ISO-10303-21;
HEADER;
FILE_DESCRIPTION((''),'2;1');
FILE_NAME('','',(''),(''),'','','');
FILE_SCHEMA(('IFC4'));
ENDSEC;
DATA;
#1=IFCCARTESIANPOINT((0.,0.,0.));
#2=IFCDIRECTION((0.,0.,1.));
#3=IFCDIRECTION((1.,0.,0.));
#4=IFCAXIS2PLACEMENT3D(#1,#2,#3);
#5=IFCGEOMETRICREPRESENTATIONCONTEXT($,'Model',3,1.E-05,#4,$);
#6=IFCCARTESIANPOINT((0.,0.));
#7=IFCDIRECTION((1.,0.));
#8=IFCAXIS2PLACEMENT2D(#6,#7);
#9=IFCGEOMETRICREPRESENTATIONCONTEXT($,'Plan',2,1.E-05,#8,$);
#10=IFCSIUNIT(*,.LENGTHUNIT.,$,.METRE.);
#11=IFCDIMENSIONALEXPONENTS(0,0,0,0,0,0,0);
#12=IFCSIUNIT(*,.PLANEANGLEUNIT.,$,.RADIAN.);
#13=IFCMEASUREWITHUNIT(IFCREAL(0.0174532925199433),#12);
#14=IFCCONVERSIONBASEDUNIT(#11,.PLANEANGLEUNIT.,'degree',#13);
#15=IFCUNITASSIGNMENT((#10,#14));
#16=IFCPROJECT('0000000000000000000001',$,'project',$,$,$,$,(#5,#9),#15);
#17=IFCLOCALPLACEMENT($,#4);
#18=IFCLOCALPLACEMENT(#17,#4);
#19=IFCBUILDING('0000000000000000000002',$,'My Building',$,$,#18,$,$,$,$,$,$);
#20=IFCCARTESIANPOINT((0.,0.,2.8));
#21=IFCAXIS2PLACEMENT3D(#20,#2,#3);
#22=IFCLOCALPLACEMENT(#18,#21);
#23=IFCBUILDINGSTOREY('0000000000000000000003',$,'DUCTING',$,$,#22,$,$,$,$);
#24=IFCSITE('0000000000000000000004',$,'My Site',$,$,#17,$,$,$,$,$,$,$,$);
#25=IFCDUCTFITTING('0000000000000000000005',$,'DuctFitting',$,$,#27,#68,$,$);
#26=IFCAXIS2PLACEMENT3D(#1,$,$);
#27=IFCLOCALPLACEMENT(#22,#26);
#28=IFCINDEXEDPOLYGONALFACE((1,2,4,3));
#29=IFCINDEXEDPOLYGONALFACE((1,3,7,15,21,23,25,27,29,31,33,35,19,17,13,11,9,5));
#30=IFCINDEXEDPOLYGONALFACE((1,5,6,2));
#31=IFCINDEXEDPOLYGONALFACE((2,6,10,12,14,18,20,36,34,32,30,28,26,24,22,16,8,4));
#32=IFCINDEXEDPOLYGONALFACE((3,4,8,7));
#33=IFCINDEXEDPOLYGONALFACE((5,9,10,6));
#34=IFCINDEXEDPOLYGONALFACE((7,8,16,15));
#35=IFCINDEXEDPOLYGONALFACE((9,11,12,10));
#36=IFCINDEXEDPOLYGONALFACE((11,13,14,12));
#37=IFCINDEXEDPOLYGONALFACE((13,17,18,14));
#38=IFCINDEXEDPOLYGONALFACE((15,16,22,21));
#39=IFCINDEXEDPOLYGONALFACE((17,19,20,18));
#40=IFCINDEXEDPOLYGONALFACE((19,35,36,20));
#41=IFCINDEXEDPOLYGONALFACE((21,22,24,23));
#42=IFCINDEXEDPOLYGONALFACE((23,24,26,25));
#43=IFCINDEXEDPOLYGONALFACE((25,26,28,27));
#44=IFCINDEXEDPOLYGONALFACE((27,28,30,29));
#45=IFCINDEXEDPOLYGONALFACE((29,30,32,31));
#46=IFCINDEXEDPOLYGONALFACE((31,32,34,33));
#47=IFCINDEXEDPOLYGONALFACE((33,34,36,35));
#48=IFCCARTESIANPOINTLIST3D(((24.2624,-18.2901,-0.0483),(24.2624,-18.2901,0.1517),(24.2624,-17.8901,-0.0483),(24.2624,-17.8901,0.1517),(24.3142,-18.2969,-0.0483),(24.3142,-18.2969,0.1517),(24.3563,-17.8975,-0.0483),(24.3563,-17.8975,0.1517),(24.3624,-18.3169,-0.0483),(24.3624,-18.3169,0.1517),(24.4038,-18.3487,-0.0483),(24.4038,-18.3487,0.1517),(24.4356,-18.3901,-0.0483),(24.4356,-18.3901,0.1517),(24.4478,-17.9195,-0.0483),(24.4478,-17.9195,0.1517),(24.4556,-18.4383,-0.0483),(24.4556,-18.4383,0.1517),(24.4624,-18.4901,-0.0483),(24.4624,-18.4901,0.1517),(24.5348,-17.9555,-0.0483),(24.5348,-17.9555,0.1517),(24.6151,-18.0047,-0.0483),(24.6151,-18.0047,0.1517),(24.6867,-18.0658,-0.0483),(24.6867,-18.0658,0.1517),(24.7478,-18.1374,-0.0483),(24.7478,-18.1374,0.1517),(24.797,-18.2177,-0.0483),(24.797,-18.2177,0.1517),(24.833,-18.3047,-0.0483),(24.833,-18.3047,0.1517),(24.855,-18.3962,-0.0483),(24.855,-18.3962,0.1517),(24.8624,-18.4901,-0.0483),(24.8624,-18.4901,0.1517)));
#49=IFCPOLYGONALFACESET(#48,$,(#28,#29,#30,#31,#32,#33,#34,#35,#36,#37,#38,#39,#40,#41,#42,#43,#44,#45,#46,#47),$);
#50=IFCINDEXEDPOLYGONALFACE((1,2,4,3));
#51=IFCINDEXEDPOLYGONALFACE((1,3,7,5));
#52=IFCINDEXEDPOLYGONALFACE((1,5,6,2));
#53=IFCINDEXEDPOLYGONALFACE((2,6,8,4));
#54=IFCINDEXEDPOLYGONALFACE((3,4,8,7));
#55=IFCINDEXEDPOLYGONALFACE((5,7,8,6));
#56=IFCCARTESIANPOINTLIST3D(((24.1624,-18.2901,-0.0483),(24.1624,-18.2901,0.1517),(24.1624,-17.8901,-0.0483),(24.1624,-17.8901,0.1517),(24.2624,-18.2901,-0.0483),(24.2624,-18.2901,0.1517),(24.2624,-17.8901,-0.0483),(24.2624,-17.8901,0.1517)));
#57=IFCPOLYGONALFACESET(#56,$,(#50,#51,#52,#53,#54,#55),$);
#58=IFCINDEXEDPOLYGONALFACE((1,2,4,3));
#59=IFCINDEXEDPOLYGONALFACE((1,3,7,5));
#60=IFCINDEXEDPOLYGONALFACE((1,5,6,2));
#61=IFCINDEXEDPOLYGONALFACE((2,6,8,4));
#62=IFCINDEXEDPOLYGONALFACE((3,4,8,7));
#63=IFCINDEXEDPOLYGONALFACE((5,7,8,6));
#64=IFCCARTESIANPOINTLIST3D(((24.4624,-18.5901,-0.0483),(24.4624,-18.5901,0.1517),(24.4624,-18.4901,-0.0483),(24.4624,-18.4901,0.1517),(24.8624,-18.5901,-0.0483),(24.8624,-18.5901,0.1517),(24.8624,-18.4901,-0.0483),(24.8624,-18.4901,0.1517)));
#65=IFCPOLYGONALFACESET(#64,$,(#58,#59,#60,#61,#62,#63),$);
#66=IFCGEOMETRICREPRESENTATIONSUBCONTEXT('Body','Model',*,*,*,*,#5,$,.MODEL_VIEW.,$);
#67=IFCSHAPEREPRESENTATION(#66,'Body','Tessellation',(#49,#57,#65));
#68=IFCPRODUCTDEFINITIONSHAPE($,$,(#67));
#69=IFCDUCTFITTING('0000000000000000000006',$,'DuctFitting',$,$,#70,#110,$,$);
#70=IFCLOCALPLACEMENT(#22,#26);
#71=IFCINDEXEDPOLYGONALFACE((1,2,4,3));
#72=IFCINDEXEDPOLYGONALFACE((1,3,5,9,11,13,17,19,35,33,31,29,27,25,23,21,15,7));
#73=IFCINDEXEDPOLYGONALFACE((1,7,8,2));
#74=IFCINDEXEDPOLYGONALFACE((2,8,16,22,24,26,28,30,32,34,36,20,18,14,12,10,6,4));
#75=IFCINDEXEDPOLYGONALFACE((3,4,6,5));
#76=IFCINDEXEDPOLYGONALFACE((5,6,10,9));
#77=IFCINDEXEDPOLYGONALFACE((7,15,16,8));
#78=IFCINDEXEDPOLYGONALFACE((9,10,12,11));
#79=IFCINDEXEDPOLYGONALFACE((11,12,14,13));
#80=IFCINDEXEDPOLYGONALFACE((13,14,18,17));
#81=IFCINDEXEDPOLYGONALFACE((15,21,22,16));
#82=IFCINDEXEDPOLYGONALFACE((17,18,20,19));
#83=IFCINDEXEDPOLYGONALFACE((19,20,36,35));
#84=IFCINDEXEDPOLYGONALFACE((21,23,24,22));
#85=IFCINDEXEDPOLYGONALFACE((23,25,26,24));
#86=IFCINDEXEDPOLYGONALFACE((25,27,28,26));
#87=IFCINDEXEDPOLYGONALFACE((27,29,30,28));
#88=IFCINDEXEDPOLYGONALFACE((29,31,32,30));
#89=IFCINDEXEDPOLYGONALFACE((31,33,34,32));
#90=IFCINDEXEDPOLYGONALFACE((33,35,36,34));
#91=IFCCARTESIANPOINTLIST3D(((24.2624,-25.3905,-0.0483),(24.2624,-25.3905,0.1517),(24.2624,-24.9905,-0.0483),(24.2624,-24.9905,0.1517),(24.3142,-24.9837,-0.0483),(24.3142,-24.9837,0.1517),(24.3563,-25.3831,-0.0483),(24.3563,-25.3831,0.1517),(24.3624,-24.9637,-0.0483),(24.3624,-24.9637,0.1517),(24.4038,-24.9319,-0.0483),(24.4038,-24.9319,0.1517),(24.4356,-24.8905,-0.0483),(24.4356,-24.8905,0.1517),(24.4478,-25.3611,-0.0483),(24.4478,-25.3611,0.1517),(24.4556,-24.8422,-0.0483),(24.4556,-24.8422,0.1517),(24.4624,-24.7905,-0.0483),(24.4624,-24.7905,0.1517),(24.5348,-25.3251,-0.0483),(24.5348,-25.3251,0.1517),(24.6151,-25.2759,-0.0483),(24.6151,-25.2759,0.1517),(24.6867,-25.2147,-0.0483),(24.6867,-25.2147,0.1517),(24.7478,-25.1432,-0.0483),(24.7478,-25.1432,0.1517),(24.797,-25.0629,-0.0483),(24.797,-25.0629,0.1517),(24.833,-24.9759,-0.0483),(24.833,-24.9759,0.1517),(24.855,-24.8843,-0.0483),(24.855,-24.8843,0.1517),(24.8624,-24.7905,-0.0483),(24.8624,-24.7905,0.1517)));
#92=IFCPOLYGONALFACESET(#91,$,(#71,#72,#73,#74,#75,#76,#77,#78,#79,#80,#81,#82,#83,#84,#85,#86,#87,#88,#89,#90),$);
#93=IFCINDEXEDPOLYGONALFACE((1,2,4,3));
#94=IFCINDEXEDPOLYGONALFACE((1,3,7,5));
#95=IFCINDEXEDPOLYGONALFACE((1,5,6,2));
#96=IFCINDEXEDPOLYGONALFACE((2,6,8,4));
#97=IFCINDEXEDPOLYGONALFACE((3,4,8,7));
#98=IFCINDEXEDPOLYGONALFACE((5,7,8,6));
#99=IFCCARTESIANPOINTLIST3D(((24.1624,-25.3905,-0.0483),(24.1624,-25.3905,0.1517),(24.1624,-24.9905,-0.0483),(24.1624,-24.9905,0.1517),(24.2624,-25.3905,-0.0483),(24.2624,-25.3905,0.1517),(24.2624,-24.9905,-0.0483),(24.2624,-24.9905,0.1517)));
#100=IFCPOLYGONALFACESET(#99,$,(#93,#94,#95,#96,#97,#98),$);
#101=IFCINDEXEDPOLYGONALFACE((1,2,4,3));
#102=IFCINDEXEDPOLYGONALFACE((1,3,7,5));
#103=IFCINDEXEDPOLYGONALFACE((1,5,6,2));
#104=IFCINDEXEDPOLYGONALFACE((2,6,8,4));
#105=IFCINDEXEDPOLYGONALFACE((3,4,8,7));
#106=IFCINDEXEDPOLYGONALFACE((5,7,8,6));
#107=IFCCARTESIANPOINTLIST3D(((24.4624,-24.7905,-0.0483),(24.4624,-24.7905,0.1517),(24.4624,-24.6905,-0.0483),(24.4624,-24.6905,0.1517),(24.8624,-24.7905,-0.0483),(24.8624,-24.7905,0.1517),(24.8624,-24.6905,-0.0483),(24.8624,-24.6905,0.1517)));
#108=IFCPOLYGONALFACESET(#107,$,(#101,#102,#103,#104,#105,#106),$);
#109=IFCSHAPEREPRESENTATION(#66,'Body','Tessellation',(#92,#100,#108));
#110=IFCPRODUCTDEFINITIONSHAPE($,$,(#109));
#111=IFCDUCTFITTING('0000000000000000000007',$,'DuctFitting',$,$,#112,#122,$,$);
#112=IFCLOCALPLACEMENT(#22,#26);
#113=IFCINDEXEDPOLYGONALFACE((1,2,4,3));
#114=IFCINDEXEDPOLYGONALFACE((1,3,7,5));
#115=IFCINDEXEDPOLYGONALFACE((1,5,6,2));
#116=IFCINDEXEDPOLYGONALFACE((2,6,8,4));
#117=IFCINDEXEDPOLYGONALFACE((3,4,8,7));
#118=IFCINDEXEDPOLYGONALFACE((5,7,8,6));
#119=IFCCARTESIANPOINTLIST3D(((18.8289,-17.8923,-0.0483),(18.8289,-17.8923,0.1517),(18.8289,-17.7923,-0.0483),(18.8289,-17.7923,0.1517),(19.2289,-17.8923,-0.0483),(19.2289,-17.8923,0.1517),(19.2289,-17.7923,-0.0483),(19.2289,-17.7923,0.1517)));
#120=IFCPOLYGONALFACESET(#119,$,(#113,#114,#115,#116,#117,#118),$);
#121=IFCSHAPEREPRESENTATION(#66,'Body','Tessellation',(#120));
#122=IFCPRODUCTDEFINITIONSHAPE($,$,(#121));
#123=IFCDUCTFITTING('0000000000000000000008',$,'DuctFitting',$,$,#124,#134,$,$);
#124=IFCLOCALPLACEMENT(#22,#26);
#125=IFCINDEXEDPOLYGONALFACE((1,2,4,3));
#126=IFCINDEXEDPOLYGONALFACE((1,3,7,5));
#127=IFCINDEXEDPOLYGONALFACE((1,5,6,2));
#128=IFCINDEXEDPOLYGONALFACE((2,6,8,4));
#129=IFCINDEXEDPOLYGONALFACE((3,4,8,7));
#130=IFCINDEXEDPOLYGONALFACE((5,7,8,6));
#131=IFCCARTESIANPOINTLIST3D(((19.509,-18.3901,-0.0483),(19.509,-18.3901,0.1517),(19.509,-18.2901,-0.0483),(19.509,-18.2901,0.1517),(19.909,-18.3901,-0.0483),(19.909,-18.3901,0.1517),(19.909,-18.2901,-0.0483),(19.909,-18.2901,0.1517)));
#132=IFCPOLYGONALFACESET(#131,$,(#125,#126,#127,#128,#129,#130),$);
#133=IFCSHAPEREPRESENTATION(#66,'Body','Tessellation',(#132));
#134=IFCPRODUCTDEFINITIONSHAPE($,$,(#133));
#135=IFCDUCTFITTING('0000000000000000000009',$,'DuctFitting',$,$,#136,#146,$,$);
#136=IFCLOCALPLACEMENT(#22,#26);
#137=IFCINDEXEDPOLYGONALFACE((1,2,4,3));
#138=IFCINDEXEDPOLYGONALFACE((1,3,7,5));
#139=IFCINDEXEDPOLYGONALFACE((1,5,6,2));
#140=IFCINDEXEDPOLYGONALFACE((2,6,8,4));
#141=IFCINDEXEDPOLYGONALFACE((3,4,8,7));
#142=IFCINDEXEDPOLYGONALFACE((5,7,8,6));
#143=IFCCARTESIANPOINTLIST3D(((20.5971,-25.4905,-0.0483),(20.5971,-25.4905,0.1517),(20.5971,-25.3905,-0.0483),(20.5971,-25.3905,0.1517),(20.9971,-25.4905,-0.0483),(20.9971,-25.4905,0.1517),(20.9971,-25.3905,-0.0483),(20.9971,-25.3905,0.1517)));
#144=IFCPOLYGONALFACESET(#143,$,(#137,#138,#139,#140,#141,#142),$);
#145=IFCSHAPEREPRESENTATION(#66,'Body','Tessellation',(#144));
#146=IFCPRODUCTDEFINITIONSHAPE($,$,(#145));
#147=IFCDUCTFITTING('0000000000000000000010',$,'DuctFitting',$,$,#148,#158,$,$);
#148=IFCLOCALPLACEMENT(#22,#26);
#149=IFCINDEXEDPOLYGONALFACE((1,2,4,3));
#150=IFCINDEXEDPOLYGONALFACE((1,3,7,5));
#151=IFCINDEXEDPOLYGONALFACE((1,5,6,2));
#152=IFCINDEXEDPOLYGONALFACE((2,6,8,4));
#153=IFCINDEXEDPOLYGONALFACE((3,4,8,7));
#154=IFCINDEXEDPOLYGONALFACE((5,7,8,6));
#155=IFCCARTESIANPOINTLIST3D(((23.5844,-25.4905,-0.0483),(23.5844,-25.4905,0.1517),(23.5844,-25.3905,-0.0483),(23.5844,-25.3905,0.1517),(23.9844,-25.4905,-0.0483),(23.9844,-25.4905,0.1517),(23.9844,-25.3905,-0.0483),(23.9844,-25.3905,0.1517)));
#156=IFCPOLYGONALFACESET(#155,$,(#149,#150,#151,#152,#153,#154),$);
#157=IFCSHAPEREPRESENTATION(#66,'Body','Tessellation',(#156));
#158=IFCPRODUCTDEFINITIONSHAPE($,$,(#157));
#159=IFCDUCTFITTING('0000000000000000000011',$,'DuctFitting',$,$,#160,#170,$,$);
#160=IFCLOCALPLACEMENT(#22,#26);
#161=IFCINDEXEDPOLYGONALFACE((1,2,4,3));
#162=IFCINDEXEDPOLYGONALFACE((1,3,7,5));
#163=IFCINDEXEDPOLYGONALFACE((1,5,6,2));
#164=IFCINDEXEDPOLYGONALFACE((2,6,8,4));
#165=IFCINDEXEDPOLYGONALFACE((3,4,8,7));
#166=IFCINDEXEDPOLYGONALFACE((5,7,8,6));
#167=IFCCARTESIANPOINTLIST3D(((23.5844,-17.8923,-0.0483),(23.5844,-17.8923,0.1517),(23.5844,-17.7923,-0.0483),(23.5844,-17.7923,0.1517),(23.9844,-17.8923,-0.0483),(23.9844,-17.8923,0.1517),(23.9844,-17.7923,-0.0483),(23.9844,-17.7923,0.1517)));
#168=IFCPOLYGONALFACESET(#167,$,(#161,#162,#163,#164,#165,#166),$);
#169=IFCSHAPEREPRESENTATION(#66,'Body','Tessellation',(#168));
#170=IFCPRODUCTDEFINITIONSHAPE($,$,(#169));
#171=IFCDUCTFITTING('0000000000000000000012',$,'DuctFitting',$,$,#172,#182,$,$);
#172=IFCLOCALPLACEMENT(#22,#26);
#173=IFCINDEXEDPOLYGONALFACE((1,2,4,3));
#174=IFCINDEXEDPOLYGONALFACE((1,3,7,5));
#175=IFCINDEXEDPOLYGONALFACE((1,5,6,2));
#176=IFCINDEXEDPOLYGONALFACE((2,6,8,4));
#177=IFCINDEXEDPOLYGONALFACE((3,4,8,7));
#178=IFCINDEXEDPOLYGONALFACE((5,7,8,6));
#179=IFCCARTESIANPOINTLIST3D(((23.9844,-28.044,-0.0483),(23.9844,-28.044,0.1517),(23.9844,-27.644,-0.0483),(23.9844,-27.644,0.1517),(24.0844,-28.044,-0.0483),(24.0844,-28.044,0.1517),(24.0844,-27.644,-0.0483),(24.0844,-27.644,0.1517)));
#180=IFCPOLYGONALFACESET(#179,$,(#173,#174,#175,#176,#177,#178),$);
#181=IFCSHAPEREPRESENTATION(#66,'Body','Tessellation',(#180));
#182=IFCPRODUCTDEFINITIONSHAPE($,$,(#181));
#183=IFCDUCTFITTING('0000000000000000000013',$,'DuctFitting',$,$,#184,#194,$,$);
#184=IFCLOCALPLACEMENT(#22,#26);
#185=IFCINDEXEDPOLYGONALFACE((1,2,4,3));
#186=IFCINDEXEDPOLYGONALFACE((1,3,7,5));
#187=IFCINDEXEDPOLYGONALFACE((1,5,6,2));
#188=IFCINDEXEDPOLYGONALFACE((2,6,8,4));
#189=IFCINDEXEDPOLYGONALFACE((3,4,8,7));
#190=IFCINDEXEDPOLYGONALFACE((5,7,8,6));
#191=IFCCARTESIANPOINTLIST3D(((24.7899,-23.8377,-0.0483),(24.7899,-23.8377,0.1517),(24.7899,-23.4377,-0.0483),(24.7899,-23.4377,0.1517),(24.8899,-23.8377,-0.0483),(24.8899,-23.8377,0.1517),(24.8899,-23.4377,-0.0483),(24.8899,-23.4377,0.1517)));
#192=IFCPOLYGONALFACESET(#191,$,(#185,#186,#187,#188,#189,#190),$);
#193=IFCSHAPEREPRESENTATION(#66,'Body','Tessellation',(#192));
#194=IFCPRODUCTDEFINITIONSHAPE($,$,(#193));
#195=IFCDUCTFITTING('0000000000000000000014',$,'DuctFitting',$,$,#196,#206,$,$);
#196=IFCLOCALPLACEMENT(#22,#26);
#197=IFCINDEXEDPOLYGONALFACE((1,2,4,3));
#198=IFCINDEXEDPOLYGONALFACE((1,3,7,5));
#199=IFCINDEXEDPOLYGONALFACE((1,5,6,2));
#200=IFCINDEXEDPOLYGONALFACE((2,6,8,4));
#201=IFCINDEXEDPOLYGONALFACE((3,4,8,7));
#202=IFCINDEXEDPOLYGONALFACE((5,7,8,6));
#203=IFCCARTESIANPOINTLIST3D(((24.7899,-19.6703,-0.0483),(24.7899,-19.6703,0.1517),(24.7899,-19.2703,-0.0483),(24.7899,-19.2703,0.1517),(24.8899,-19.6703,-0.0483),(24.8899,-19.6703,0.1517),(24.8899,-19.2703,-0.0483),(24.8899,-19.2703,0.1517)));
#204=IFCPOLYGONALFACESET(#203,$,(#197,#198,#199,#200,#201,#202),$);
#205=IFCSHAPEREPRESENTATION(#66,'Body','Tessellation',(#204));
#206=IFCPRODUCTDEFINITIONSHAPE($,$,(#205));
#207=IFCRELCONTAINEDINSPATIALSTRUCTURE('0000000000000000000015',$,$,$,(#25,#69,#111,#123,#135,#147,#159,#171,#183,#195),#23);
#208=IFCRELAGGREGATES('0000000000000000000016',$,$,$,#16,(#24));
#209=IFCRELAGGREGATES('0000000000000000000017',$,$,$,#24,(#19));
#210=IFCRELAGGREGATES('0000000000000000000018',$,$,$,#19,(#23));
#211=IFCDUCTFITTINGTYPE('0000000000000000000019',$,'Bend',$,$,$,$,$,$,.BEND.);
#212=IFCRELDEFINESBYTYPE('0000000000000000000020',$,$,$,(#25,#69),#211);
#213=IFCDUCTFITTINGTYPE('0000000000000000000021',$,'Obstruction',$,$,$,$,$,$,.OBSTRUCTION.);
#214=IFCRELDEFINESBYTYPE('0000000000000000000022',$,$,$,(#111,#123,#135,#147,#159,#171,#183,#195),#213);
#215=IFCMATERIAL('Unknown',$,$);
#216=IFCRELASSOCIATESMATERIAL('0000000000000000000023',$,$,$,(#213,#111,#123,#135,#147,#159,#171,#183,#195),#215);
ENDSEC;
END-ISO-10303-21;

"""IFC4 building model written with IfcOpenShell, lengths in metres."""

from ifc_helpers import new_model, entity, si_unit, converted_unit, frame, origin_with_axes, origin_2d_with_axis, place, context, subcontext, project, spatial, line, arc, indexed_curve, rectangle, outline, extrude, source, transform, mapped, material, material_profile, profile_set, profile_usage, type_object, type_shapes, element, save


model = new_model("IFC4")

# Units and contexts
model_context = context("Model", 3, precision=1e-05, world=origin_with_axes())
plan_context = context("Plan", 2, precision=1e-05, world=origin_2d_with_axis())
body_context = subcontext(model_context, "Body", "Model", "MODEL_VIEW")
ifc_project = project(units=[si_unit("LENGTHUNIT", "METRE"), converted_unit("PLANEANGLEUNIT", "degree", entity("IfcReal", 0.0174532925199433), si_unit("PLANEANGLEUNIT", "RADIAN"), dimensions=[0, 0, 0, 0, 0, 0, 0])], contexts=[model_context, plan_context])

# Site, building, storey
site_placement = place(None, origin_with_axes())
site = spatial("IfcSite", under=ifc_project, at=site_placement, Name="My Site")
building_placement = place(site_placement, origin_with_axes())
building = spatial("IfcBuilding", under=site, at=building_placement, Name="My Building")
storey_placement = place(building_placement, frame((0.0, 0.0, 2.8), z_axis=(0.0, 0.0, 1.0), x_axis=(1.0, 0.0, 0.0)))
storey = spatial("IfcBuildingStorey", under=building, at=storey_placement, Name="DUCTING")

# Shared definitions
ifc_material = material(Name="Unknown")

# Duct fittings
duct_fitting_type_1 = type_object("IfcDuctFittingType", Name="Bend", PredefinedType="BEND")
shared_shape = source(origin_with_axes(), body_context, "Body", "SweptSolid", [
    extrude(outline(indexed_curve([(0.2, 0.0), (0.2586, -0.1414), (0.4, -0.2), (0.4, -0.6), (-0.0243, -0.4243), (-0.2, 0.0)], segments=[arc(1, 2, 3), line(3, 4), arc(4, 5, 6), line(6, 1)])), frame((0.0, -0.1, -0.1), z_axis=(0.0, -1.0, 0.0), x_axis=(1.0, 0.0, 0.0)), (0.0, 0.0, -1.0), 0.2),
    extrude(rectangle(XDim=0.4, YDim=0.2), origin_with_axes(), (0.0, 0.0, -1.0), 0.1),
    extrude(rectangle(XDim=0.4, YDim=0.2), frame((0.4, 0.0, -0.5), z_axis=(1.0, 0.0, 0.0), x_axis=(0.0, 0.0, 1.0)), (0.0, 0.0, 1.0), 0.1),
])
type_shapes(duct_fitting_type_1, [shared_shape])
for number, where, z_axis, x_axis, name in (
    (1, (24.1624, -18.0901, 0.0517), (-1.0, 0.0, 0.0), (0.0, -1.0, 0.0), "DuctFitting"),
    (2, (24.1624, -25.1905, 0.0517), (-1.0, 0.0, 0.0), (0.0, 1.0, 0.0), "DuctFitting"),
):
    element("IfcDuctFitting", number, at=place(storey_placement, frame(where, z_axis=z_axis, x_axis=x_axis)), inside=storey, type_object=duct_fitting_type_1, Name=name, context=body_context, shape_type="MappedRepresentation", body=[
        mapped(shared_shape, transform((0.0, 0.0, 0.0), x_axis=(1.0, 0.0, 0.0), y_axis=(0.0, 1.0, 0.0), z_axis=(0.0, 0.0, 1.0), scale=1.0)),
    ])
ifc_material_profile_1 = material_profile(ifc_material, rectangle(XDim=0.4, YDim=0.2))
ifc_profile_set_1 = profile_set([ifc_material_profile_1])
ifc_profile_usage_1 = profile_usage(ifc_profile_set_1, cardinal=5)
duct_fitting_type_2 = type_object("IfcDuctFittingType", Name="Obstruction", PredefinedType="OBSTRUCTION", material=ifc_profile_set_1)
duct_fitting_1_placement = place(storey_placement, frame((19.0289, -17.7923, 0.0517), z_axis=(0.0, -1.0, 0.0), x_axis=(1.0, 0.0, 0.0)))
element("IfcDuctFitting", 3, at=duct_fitting_1_placement, inside=storey, type_object=duct_fitting_type_2, material=ifc_profile_usage_1, Name="DuctFitting", context=body_context, shape_type="SweptSolid", body=[
    extrude(rectangle(XDim=0.4, YDim=0.2), origin_with_axes(), (0.0, 0.0, 1.0), 0.1),
])
ifc_profile_usage_2 = profile_usage(ifc_profile_set_1, cardinal=5)
duct_fitting_2_placement = place(storey_placement, frame((19.709, -18.3901, 0.0517), z_axis=(0.0, 1.0, 0.0), x_axis=(-1.0, 0.0, 0.0)))
element("IfcDuctFitting", 4, at=duct_fitting_2_placement, inside=storey, type_object=duct_fitting_type_2, material=ifc_profile_usage_2, Name="DuctFitting", context=body_context, shape_type="SweptSolid", body=[
    extrude(rectangle(XDim=0.4, YDim=0.2), origin_with_axes(), (0.0, 0.0, 1.0), 0.1),
])
ifc_profile_usage_3 = profile_usage(ifc_profile_set_1, cardinal=5)
duct_fitting_3_placement = place(storey_placement, frame((20.7971, -25.4905, 0.0517), z_axis=(0.0, 1.0, 0.0), x_axis=(-1.0, 0.0, 0.0)))
element("IfcDuctFitting", 5, at=duct_fitting_3_placement, inside=storey, type_object=duct_fitting_type_2, material=ifc_profile_usage_3, Name="DuctFitting", context=body_context, shape_type="SweptSolid", body=[
    extrude(rectangle(XDim=0.4, YDim=0.2), origin_with_axes(), (0.0, 0.0, 1.0), 0.1),
])
ifc_profile_usage_4 = profile_usage(ifc_profile_set_1, cardinal=5)
duct_fitting_4_placement = place(storey_placement, frame((23.7844, -25.4905, 0.0517), z_axis=(0.0, 1.0, 0.0), x_axis=(-1.0, 0.0, 0.0)))
element("IfcDuctFitting", 6, at=duct_fitting_4_placement, inside=storey, type_object=duct_fitting_type_2, material=ifc_profile_usage_4, Name="DuctFitting", context=body_context, shape_type="SweptSolid", body=[
    extrude(rectangle(XDim=0.4, YDim=0.2), origin_with_axes(), (0.0, 0.0, 1.0), 0.1),
])
ifc_profile_usage_5 = profile_usage(ifc_profile_set_1, cardinal=5)
duct_fitting_5_placement = place(storey_placement, frame((23.7844, -17.7923, 0.0517), z_axis=(0.0, -1.0, 0.0), x_axis=(1.0, 0.0, 0.0)))
element("IfcDuctFitting", 7, at=duct_fitting_5_placement, inside=storey, type_object=duct_fitting_type_2, material=ifc_profile_usage_5, Name="DuctFitting", context=body_context, shape_type="SweptSolid", body=[
    extrude(rectangle(XDim=0.4, YDim=0.2), origin_with_axes(), (0.0, 0.0, 1.0), 0.1),
])
ifc_profile_usage_6 = profile_usage(ifc_profile_set_1, cardinal=5)
duct_fitting_6_placement = place(storey_placement, frame((24.0844, -27.844, 0.0517), z_axis=(-1.0, 0.0, 0.0), x_axis=(0.0, -1.0, 0.0)))
element("IfcDuctFitting", 8, at=duct_fitting_6_placement, inside=storey, type_object=duct_fitting_type_2, material=ifc_profile_usage_6, Name="DuctFitting", context=body_context, shape_type="SweptSolid", body=[
    extrude(rectangle(XDim=0.4, YDim=0.2), origin_with_axes(), (0.0, 0.0, 1.0), 0.1),
])
ifc_profile_usage_7 = profile_usage(ifc_profile_set_1, cardinal=5)
duct_fitting_7_placement = place(storey_placement, frame((24.8899, -23.6377, 0.0517), z_axis=(-1.0, 0.0, 0.0), x_axis=(0.0, -1.0, 0.0)))
element("IfcDuctFitting", 9, at=duct_fitting_7_placement, inside=storey, type_object=duct_fitting_type_2, material=ifc_profile_usage_7, Name="DuctFitting", context=body_context, shape_type="SweptSolid", body=[
    extrude(rectangle(XDim=0.4, YDim=0.2), origin_with_axes(), (0.0, 0.0, 1.0), 0.1),
])
ifc_profile_usage_8 = profile_usage(ifc_profile_set_1, cardinal=5)
duct_fitting_8_placement = place(storey_placement, frame((24.8899, -19.4703, 0.0517), z_axis=(-1.0, 0.0, 0.0), x_axis=(0.0, -1.0, 0.0)))
element("IfcDuctFitting", 10, at=duct_fitting_8_placement, inside=storey, type_object=duct_fitting_type_2, material=ifc_profile_usage_8, Name="DuctFitting", context=body_context, shape_type="SweptSolid", body=[
    extrude(rectangle(XDim=0.4, YDim=0.2), origin_with_axes(), (0.0, 0.0, 1.0), 0.1),
])

save(model, "model.ifc")
